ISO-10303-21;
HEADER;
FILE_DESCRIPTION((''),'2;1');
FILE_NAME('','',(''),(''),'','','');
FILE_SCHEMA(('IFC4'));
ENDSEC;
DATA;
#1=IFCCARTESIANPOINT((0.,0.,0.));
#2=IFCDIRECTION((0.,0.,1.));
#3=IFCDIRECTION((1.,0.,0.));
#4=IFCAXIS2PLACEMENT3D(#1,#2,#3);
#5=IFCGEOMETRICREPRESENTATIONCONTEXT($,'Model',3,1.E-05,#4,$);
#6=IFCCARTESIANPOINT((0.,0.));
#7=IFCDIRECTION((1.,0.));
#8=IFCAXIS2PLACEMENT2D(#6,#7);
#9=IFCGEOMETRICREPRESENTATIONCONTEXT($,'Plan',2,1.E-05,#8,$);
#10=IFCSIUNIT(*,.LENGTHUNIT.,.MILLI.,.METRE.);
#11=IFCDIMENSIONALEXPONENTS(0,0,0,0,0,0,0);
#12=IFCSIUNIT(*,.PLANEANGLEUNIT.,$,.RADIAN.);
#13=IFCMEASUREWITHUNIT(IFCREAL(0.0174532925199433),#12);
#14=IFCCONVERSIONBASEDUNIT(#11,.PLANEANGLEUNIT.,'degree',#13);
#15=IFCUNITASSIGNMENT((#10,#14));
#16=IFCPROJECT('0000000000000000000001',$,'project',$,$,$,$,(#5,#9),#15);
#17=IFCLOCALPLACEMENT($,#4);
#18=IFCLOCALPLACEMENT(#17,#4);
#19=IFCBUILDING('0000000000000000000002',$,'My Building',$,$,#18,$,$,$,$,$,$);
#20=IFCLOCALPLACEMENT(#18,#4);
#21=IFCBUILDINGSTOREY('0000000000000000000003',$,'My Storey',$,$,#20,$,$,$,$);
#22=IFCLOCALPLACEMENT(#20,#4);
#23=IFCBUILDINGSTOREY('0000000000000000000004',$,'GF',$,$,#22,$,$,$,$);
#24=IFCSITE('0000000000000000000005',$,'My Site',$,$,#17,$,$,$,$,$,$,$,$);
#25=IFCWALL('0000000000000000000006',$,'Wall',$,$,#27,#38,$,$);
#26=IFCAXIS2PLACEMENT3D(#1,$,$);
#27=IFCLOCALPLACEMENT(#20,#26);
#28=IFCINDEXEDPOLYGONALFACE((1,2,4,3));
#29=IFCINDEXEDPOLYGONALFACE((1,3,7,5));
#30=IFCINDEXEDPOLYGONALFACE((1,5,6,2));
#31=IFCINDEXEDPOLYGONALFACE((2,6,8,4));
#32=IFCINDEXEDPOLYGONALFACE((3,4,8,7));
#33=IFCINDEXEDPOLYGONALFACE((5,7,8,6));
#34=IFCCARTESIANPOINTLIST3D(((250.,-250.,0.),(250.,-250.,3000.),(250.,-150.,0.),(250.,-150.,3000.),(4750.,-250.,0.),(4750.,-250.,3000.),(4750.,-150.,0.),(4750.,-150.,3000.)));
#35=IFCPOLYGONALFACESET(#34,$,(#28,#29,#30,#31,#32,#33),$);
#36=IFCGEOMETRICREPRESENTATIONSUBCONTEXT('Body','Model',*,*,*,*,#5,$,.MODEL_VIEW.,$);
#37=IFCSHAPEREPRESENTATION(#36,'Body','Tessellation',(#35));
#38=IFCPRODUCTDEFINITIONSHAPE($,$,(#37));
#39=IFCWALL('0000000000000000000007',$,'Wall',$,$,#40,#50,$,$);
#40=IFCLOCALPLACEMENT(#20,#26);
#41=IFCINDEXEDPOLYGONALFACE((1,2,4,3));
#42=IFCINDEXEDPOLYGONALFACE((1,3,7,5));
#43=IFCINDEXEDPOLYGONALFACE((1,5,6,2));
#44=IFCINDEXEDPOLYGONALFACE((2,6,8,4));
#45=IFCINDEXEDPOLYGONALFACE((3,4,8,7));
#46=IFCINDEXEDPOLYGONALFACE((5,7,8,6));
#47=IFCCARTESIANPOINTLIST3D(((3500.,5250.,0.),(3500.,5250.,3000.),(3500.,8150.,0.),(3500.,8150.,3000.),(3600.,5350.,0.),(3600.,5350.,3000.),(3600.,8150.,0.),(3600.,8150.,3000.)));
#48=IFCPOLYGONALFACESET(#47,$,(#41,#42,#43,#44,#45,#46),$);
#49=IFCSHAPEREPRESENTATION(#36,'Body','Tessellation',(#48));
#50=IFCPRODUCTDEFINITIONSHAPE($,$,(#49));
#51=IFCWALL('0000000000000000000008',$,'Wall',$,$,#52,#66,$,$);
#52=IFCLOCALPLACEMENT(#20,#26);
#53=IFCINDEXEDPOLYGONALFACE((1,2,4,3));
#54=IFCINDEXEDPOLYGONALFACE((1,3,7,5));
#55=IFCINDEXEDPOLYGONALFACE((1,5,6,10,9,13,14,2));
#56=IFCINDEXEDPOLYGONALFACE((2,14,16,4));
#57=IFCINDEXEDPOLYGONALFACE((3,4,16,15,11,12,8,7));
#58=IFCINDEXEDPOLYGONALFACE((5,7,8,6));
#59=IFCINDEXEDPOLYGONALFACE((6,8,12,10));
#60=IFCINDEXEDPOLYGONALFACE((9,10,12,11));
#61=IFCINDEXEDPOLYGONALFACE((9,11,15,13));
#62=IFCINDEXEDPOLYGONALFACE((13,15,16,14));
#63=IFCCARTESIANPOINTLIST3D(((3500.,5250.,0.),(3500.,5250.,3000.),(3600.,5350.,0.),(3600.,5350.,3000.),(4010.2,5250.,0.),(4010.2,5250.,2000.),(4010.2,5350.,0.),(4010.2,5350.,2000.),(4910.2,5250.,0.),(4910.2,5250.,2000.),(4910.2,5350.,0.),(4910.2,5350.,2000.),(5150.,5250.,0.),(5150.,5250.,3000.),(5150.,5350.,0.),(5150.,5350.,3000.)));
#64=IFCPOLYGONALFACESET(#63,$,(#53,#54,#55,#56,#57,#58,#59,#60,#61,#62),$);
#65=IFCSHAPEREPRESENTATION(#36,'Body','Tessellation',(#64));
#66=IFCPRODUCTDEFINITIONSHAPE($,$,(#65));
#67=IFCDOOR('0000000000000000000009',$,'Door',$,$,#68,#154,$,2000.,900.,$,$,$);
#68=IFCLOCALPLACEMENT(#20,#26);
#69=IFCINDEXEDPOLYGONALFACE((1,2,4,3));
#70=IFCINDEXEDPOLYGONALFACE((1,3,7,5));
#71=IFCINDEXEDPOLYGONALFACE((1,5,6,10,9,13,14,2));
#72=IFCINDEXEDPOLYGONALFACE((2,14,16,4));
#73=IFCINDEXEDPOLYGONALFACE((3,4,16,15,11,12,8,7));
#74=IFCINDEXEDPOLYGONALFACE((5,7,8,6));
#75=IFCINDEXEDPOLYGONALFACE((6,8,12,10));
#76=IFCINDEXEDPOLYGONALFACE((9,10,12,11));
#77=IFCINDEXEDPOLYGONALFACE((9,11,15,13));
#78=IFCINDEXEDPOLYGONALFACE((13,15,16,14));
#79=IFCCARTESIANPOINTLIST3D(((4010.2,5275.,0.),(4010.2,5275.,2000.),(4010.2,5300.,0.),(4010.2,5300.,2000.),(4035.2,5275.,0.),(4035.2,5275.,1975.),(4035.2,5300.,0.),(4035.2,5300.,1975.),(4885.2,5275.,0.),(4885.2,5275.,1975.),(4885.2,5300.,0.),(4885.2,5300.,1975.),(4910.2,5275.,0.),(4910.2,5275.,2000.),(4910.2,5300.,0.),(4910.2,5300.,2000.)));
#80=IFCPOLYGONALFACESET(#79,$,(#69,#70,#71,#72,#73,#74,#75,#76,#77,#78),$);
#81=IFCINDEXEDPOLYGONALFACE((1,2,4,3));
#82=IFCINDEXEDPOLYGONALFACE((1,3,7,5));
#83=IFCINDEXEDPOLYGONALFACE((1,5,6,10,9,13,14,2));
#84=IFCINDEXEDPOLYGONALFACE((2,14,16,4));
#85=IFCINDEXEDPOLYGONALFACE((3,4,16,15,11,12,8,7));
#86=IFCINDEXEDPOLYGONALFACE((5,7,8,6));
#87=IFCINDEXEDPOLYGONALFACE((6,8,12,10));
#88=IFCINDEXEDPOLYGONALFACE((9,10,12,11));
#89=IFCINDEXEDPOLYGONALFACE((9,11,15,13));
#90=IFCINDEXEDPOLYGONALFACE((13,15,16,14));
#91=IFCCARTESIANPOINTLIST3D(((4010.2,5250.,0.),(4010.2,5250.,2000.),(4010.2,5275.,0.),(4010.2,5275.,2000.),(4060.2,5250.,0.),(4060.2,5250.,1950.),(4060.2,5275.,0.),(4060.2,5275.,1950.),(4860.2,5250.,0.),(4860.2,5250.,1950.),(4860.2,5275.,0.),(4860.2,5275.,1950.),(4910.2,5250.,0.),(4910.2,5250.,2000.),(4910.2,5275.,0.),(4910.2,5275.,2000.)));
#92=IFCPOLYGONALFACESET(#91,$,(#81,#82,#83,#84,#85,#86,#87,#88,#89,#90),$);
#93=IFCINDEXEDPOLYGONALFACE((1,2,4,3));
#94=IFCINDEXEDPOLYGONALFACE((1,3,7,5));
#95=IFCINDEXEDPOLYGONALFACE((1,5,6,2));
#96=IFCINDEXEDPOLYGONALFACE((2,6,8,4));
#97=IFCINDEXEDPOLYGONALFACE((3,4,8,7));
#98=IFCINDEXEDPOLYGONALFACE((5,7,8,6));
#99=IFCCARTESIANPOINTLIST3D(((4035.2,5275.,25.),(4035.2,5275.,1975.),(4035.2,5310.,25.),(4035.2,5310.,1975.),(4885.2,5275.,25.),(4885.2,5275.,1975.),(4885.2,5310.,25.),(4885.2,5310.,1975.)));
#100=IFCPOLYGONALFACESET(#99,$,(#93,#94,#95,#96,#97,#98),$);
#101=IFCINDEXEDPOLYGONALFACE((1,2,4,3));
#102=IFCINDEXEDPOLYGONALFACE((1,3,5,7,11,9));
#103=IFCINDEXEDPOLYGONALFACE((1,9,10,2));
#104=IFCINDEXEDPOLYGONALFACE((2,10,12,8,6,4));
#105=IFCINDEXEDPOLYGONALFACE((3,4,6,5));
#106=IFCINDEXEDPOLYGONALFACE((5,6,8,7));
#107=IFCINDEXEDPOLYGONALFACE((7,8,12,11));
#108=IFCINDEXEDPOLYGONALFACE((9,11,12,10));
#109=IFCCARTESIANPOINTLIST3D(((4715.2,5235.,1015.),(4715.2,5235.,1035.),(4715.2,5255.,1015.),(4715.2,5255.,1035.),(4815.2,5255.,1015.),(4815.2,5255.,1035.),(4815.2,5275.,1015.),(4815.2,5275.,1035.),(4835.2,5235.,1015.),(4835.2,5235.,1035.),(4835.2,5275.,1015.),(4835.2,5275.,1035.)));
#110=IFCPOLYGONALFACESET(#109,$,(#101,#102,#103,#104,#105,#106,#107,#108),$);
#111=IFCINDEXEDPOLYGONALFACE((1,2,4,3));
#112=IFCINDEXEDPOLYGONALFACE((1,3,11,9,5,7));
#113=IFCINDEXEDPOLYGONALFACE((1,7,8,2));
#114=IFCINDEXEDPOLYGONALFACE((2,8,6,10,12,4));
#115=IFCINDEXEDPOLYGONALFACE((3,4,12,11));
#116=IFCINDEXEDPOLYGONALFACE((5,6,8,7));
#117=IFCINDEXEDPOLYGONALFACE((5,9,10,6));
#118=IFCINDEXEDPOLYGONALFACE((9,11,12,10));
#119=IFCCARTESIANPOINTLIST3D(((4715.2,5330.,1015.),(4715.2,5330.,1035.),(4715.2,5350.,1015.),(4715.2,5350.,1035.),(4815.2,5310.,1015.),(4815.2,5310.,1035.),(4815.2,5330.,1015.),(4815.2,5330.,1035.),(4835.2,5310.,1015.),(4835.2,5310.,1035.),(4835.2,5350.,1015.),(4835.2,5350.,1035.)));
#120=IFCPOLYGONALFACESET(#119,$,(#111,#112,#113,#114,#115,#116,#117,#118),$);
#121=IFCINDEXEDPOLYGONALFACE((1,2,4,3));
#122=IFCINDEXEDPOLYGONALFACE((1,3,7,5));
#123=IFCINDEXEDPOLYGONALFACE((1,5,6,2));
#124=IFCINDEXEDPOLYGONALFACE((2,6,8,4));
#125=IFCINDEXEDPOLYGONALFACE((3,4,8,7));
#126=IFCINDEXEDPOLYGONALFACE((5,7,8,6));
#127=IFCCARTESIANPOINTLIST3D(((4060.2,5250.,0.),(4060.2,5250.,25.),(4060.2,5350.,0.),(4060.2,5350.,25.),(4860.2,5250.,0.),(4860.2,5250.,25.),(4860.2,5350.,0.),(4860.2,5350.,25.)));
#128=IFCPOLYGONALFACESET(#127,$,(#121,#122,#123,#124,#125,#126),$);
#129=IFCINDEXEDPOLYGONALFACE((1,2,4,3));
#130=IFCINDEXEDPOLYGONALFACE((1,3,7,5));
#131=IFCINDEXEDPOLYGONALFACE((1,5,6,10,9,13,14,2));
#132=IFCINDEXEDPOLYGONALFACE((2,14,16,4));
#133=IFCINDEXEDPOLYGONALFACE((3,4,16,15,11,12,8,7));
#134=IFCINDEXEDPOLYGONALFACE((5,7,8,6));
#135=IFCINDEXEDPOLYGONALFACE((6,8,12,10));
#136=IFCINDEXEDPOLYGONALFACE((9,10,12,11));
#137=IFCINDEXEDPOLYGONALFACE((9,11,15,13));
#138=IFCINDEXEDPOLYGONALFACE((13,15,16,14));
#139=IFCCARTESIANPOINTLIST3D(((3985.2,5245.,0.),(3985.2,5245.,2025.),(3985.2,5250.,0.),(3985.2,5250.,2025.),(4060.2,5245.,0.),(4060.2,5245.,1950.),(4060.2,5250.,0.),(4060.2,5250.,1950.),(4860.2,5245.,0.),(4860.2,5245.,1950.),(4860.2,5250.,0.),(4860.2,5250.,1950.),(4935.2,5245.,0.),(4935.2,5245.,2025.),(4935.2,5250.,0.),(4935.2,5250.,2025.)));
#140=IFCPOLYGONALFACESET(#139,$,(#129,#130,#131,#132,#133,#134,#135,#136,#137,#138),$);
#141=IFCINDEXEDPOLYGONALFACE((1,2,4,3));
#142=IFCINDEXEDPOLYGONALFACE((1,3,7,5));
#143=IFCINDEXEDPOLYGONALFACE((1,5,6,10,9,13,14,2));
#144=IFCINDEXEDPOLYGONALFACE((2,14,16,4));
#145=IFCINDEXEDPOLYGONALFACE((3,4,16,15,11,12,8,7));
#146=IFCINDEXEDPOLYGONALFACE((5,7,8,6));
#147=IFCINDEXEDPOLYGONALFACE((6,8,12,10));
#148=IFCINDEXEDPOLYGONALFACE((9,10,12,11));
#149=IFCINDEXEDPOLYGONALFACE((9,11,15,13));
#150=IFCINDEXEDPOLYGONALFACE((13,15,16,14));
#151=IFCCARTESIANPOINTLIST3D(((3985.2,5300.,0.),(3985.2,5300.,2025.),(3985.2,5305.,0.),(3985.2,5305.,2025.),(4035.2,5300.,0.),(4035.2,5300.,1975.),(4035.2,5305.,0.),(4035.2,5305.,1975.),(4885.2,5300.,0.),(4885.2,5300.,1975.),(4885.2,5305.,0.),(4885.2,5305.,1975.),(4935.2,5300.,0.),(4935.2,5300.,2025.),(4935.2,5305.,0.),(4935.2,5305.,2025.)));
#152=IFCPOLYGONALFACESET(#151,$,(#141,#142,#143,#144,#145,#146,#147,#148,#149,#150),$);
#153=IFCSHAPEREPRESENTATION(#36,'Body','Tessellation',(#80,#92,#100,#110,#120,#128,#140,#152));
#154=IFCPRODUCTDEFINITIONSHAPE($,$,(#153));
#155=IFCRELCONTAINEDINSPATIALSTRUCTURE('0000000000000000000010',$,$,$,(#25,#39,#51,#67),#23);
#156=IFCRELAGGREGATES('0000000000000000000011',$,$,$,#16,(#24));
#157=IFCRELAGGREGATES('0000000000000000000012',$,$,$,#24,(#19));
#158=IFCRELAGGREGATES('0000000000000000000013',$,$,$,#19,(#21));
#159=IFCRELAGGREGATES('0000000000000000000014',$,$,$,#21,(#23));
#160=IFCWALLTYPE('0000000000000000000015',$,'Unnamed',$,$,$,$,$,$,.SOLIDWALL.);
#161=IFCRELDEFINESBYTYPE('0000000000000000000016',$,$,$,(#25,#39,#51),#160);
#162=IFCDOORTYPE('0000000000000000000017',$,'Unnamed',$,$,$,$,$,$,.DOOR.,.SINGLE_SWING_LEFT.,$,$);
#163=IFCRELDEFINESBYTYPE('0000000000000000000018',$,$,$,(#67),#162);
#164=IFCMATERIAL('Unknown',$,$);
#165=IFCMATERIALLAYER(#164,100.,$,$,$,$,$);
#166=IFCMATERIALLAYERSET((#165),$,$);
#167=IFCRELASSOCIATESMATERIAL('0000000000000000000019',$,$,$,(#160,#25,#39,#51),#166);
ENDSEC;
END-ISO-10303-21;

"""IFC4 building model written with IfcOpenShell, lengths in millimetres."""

from ifc_helpers import new_model, entity, si_unit, converted_unit, frame, origin_with_axes, origin_2d_with_axis, place, context, subcontext, project, spatial, line, indexed_curve, outline, extrude, shape, source, transform, mapped, material, layer, layer_set, layer_usage, type_object, type_shapes, element, fill, save


model = new_model("IFC4")

# Units and contexts
model_context = context("Model", 3, precision=1e-05, world=origin_with_axes())
plan_context = context("Plan", 2, precision=1e-05, world=origin_2d_with_axis())
body_context_1 = subcontext(model_context, "Body", "Model", "MODEL_VIEW")
body_context_2 = subcontext(plan_context, "Body", "Plan", "PLAN_VIEW")
ifc_project = project(units=[si_unit("LENGTHUNIT", "METRE", prefix="MILLI"), converted_unit("PLANEANGLEUNIT", "degree", entity("IfcReal", 0.0174532925199433), si_unit("PLANEANGLEUNIT", "RADIAN"), dimensions=[0, 0, 0, 0, 0, 0, 0])], contexts=[model_context, plan_context])

# Site, building, storeys
site_placement = place(None, origin_with_axes())
site = spatial("IfcSite", under=ifc_project, at=site_placement, Name="My Site")
building_placement = place(site_placement, origin_with_axes())
building = spatial("IfcBuilding", under=site, at=building_placement, Name="My Building")
storey_1_placement = place(building_placement, origin_with_axes())
storey_1 = spatial("IfcBuildingStorey", under=building, at=storey_1_placement, Name="My Storey")
storey_2_placement = place(storey_1_placement, origin_with_axes())
storey_2 = spatial("IfcBuildingStorey", under=storey_1, at=storey_2_placement, Name="GF")

# Walls
ifc_material = material(Name="Unknown")
ifc_layer_1 = layer(ifc_material, 100.0)
ifc_layer_set_1 = layer_set([ifc_layer_1])
ifc_layer_usage_1 = layer_usage(ifc_layer_set_1, "AXIS2", "POSITIVE", 0.0)
wall_type_1 = type_object("IfcWallType", Name="Unnamed", PredefinedType="SOLIDWALL", material=ifc_layer_set_1)
wall_1_placement = place(storey_2_placement, frame((4750.0, -150.0, 0.0), z_axis=(0.0, 0.0, 1.0), x_axis=(-1.0, 0.0, 0.0)))
element("IfcWall", 1, at=wall_1_placement, inside=storey_2, type_object=wall_type_1, material=ifc_layer_usage_1, Name="Wall", context=body_context_1, shape_type="SweptSolid", body=[
    extrude(outline(indexed_curve([(0.0, 0.0), (0.0, 100.0), (4500.0, 100.0), (4500.0, 0.0)], segments=[line(1, 2, 3, 4, 1)])), origin_with_axes(), (0.0, 0.0, 1.0), 3000.0),
])
ifc_layer_usage_2 = layer_usage(ifc_layer_set_1, "AXIS2", "POSITIVE", 0.0)
wall_2_placement = place(storey_2_placement, frame((3500.0, 8150.0, 0.0), z_axis=(0.0, 0.0, 1.0), x_axis=(0.0, -1.0, 0.0)))
element("IfcWall", 2, at=wall_2_placement, inside=storey_2, type_object=wall_type_1, material=ifc_layer_usage_2, Name="Wall", context=body_context_1, shape_type="SweptSolid", body=[
    extrude(outline(indexed_curve([(0.0, 0.0), (0.0, 100.0), (2800.0, 100.0), (2900.0, 0.0)], segments=[line(1, 2, 3, 4, 1)])), origin_with_axes(), (0.0, 0.0, 1.0), 3000.0),
])

# Wall, opening, door
ifc_layer_usage_3 = layer_usage(ifc_layer_set_1, "AXIS2", "POSITIVE", 0.0)
wall_3_placement = place(storey_2_placement, frame((3500.0, 5250.0, 0.0), z_axis=(0.0, 0.0, 1.0), x_axis=(1.0, 0.0, 0.0)))
wall_3 = element("IfcWall", 3, at=wall_3_placement, inside=storey_2, type_object=wall_type_1, material=ifc_layer_usage_3, Name="Wall", context=body_context_1, shape_type="SweptSolid", body=[
    extrude(outline(indexed_curve([(0.0, 0.0), (100.0, 100.0), (1650.0, 100.0), (1650.0, 0.0)], segments=[line(1, 2, 3, 4, 1)])), origin_with_axes(), (0.0, 0.0, 1.0), 3000.0),
])
shared_shape_1 = source(origin_with_axes(), body_context_1, "Body", "SweptSolid", [
    extrude(outline(indexed_curve([(0.0, 0.0), (900.0, 0.0), (900.0, 2000.0), (0.0, 2000.0)], segments=[line(1, 2, 3, 4, 1)])), frame((0.0, -600.0, 0.0), z_axis=(0.0, -1.0, 0.0), x_axis=(1.0, 0.0, 0.0)), (0.0, 0.0, -1.0), 1200.0),
])
opening_1_placement = place(wall_3_placement, frame((510.2, 0.0, 0.0), z_axis=(0.0, 0.0, 1.0), x_axis=(1.0, 0.0, 0.0)))
opening_1 = element("IfcOpeningElement", 4, at=opening_1_placement, cuts=wall_3, PredefinedType="OPENING", context=body_context_1, shape_type="MappedRepresentation", body=[
    mapped(shared_shape_1, transform((0.0, 0.0, 0.0), x_axis=(1.0, 0.0, 0.0), y_axis=(0.0, 1.0, 0.0), z_axis=(0.0, 0.0, 1.0), scale=1.0)),
])
door_type = type_object("IfcDoorType", Name="Unnamed", OperationType="SINGLE_SWING_LEFT", PredefinedType="DOOR")
shared_shape_2 = source(origin_with_axes(), body_context_1, "Body", "SweptSolid", [
    extrude(outline(indexed_curve([(0.0, 0.0), (0.0, 2000.0), (900.0, 2000.0), (900.0, 0.0), (875.0, 0.0), (875.0, 1975.0), (25.0, 1975.0), (25.0, 0.0)], segments=[line(1, 2, 3, 4, 5, 6, 7, 8, 1)])), frame((0.0, 25.0, 0.0), z_axis=(0.0, -1.0, 0.0), x_axis=(1.0, 0.0, 0.0)), (0.0, 0.0, -1.0), 25.0),
    extrude(outline(indexed_curve([(0.0, 0.0), (0.0, 2000.0), (900.0, 2000.0), (900.0, 0.0), (850.0, 0.0), (850.0, 1950.0), (50.0, 1950.0), (50.0, 0.0)], segments=[line(1, 2, 3, 4, 5, 6, 7, 8, 1)])), frame((0.0, 0.0, 0.0), z_axis=(0.0, -1.0, 0.0), x_axis=(1.0, 0.0, 0.0)), (0.0, 0.0, -1.0), 25.0),
    extrude(outline(indexed_curve([(0.0, 0.0), (850.0, 0.0), (850.0, 35.0), (0.0, 35.0)], segments=[line(1, 2, 3, 4, 1)])), frame((25.0, 25.0, 25.0), z_axis=(0.0, 0.0, 1.0), x_axis=(1.0, 0.0, 0.0)), (0.0, 0.0, 1.0), 1950.0),
    extrude(outline(indexed_curve([(0.0, 0.0), (0.0, -40.0), (-120.0, -40.0), (-120.0, -20.0), (-20.0, -20.0), (-20.0, 0.0)], segments=[line(1, 2, 3, 4, 5, 6, 1)])), frame((825.0, 25.0, 1015.0), z_axis=(0.0, 0.0, 1.0), x_axis=(1.0, 0.0, 0.0)), (0.0, 0.0, 1.0), 20.0),
    extrude(outline(indexed_curve([(0.0, 0.0), (0.0, 40.0), (-120.0, 40.0), (-120.0, 20.0), (-20.0, 20.0), (-20.0, 0.0)], segments=[line(1, 2, 3, 4, 5, 6, 1)])), frame((825.0, 60.0, 1015.0), z_axis=(0.0, 0.0, 1.0), x_axis=(1.0, 0.0, 0.0)), (0.0, 0.0, 1.0), 20.0),
    extrude(outline(indexed_curve([(0.0, 0.0), (800.0, 0.0), (800.0, 100.0), (0.0, 100.0)], segments=[line(1, 2, 3, 4, 1)])), frame((50.0, 0.0, 0.0), z_axis=(0.0, 0.0, 1.0), x_axis=(1.0, 0.0, 0.0)), (0.0, 0.0, 1.0), 25.0),
    extrude(outline(indexed_curve([(0.0, 0.0), (0.0, 2025.0), (950.0, 2025.0), (950.0, 0.0), (875.0, 0.0), (875.0, 1950.0), (75.0, 1950.0), (75.0, 0.0)], segments=[line(1, 2, 3, 4, 5, 6, 7, 8, 1)])), frame((-25.0, -5.0, 0.0), z_axis=(0.0, -1.0, 0.0), x_axis=(1.0, 0.0, 0.0)), (0.0, 0.0, -1.0), 5.0),
    extrude(outline(indexed_curve([(0.0, 0.0), (0.0, 2025.0), (950.0, 2025.0), (950.0, 0.0), (900.0, 0.0), (900.0, 1975.0), (50.0, 1975.0), (50.0, 0.0)], segments=[line(1, 2, 3, 4, 5, 6, 7, 8, 1)])), frame((-25.0, 50.0, 0.0), z_axis=(0.0, -1.0, 0.0), x_axis=(1.0, 0.0, 0.0)), (0.0, 0.0, -1.0), 5.0),
])
shared_shape_3 = source(origin_with_axes(), body_context_2, "Body", "Curve2D", [
    entity("IfcIndexedPolyCurve", entity("IfcCartesianPointList2D", [[0.0, 0.0], [0.0, 50.0], [25.0, 50.0], [25.0, 25.0], [50.0, 25.0], [50.0, 0.0]]), [entity("IfcLineIndex", [1, 2, 3, 4, 5, 6, 1])]),
    entity("IfcIndexedPolyCurve", entity("IfcCartesianPointList2D", [[900.0, 0.0], [900.0, 50.0], [875.0, 50.0], [875.0, 25.0], [850.0, 25.0], [850.0, 0.0]]), [entity("IfcLineIndex", [1, 2, 3, 4, 5, 6, 1])]),
    entity("IfcTrimmedCurve", entity("IfcEllipse", entity("IfcAxis2Placement2D", entity("IfcCartesianPoint", [60.0, 50.0]), entity("IfcDirection", [1.0, 0.0])), 815.0, 850.0), [entity("IfcCartesianPoint", [875.0, 50.0])], [entity("IfcCartesianPoint", [60.0, 900.0])], True, "CARTESIAN"),
    entity("IfcIndexedPolyCurve", entity("IfcCartesianPointList2D", [[25.0, 50.0], [60.0, 50.0], [60.0, 900.0], [25.0, 900.0]]), [entity("IfcLineIndex", [1, 2, 3, 4, 1])]),
])
type_shapes(door_type, [shared_shape_2, shared_shape_3])
door_1_placement = place(opening_1_placement, origin_with_axes())
door_1 = element("IfcDoor", 5, at=door_1_placement, inside=storey_2, type_object=door_type, Name="Door", OverallHeight=2000.0, OverallWidth=900.0, shapes=[
    shape(body_context_1, "Body", "MappedRepresentation", [mapped(shared_shape_2, transform((0.0, 0.0, 0.0), x_axis=(1.0, 0.0, 0.0), y_axis=(0.0, 1.0, 0.0), z_axis=(0.0, 0.0, 1.0), scale=1.0))]),
    shape(body_context_2, "Body", "MappedRepresentation", [mapped(shared_shape_3, transform((0.0, 0.0, 0.0), x_axis=(1.0, 0.0, 0.0), y_axis=(0.0, 1.0, 0.0), z_axis=(0.0, 0.0, 1.0), scale=1.0))]),
])
fill(opening_1, door_1)

save(model, "model.ifc")
